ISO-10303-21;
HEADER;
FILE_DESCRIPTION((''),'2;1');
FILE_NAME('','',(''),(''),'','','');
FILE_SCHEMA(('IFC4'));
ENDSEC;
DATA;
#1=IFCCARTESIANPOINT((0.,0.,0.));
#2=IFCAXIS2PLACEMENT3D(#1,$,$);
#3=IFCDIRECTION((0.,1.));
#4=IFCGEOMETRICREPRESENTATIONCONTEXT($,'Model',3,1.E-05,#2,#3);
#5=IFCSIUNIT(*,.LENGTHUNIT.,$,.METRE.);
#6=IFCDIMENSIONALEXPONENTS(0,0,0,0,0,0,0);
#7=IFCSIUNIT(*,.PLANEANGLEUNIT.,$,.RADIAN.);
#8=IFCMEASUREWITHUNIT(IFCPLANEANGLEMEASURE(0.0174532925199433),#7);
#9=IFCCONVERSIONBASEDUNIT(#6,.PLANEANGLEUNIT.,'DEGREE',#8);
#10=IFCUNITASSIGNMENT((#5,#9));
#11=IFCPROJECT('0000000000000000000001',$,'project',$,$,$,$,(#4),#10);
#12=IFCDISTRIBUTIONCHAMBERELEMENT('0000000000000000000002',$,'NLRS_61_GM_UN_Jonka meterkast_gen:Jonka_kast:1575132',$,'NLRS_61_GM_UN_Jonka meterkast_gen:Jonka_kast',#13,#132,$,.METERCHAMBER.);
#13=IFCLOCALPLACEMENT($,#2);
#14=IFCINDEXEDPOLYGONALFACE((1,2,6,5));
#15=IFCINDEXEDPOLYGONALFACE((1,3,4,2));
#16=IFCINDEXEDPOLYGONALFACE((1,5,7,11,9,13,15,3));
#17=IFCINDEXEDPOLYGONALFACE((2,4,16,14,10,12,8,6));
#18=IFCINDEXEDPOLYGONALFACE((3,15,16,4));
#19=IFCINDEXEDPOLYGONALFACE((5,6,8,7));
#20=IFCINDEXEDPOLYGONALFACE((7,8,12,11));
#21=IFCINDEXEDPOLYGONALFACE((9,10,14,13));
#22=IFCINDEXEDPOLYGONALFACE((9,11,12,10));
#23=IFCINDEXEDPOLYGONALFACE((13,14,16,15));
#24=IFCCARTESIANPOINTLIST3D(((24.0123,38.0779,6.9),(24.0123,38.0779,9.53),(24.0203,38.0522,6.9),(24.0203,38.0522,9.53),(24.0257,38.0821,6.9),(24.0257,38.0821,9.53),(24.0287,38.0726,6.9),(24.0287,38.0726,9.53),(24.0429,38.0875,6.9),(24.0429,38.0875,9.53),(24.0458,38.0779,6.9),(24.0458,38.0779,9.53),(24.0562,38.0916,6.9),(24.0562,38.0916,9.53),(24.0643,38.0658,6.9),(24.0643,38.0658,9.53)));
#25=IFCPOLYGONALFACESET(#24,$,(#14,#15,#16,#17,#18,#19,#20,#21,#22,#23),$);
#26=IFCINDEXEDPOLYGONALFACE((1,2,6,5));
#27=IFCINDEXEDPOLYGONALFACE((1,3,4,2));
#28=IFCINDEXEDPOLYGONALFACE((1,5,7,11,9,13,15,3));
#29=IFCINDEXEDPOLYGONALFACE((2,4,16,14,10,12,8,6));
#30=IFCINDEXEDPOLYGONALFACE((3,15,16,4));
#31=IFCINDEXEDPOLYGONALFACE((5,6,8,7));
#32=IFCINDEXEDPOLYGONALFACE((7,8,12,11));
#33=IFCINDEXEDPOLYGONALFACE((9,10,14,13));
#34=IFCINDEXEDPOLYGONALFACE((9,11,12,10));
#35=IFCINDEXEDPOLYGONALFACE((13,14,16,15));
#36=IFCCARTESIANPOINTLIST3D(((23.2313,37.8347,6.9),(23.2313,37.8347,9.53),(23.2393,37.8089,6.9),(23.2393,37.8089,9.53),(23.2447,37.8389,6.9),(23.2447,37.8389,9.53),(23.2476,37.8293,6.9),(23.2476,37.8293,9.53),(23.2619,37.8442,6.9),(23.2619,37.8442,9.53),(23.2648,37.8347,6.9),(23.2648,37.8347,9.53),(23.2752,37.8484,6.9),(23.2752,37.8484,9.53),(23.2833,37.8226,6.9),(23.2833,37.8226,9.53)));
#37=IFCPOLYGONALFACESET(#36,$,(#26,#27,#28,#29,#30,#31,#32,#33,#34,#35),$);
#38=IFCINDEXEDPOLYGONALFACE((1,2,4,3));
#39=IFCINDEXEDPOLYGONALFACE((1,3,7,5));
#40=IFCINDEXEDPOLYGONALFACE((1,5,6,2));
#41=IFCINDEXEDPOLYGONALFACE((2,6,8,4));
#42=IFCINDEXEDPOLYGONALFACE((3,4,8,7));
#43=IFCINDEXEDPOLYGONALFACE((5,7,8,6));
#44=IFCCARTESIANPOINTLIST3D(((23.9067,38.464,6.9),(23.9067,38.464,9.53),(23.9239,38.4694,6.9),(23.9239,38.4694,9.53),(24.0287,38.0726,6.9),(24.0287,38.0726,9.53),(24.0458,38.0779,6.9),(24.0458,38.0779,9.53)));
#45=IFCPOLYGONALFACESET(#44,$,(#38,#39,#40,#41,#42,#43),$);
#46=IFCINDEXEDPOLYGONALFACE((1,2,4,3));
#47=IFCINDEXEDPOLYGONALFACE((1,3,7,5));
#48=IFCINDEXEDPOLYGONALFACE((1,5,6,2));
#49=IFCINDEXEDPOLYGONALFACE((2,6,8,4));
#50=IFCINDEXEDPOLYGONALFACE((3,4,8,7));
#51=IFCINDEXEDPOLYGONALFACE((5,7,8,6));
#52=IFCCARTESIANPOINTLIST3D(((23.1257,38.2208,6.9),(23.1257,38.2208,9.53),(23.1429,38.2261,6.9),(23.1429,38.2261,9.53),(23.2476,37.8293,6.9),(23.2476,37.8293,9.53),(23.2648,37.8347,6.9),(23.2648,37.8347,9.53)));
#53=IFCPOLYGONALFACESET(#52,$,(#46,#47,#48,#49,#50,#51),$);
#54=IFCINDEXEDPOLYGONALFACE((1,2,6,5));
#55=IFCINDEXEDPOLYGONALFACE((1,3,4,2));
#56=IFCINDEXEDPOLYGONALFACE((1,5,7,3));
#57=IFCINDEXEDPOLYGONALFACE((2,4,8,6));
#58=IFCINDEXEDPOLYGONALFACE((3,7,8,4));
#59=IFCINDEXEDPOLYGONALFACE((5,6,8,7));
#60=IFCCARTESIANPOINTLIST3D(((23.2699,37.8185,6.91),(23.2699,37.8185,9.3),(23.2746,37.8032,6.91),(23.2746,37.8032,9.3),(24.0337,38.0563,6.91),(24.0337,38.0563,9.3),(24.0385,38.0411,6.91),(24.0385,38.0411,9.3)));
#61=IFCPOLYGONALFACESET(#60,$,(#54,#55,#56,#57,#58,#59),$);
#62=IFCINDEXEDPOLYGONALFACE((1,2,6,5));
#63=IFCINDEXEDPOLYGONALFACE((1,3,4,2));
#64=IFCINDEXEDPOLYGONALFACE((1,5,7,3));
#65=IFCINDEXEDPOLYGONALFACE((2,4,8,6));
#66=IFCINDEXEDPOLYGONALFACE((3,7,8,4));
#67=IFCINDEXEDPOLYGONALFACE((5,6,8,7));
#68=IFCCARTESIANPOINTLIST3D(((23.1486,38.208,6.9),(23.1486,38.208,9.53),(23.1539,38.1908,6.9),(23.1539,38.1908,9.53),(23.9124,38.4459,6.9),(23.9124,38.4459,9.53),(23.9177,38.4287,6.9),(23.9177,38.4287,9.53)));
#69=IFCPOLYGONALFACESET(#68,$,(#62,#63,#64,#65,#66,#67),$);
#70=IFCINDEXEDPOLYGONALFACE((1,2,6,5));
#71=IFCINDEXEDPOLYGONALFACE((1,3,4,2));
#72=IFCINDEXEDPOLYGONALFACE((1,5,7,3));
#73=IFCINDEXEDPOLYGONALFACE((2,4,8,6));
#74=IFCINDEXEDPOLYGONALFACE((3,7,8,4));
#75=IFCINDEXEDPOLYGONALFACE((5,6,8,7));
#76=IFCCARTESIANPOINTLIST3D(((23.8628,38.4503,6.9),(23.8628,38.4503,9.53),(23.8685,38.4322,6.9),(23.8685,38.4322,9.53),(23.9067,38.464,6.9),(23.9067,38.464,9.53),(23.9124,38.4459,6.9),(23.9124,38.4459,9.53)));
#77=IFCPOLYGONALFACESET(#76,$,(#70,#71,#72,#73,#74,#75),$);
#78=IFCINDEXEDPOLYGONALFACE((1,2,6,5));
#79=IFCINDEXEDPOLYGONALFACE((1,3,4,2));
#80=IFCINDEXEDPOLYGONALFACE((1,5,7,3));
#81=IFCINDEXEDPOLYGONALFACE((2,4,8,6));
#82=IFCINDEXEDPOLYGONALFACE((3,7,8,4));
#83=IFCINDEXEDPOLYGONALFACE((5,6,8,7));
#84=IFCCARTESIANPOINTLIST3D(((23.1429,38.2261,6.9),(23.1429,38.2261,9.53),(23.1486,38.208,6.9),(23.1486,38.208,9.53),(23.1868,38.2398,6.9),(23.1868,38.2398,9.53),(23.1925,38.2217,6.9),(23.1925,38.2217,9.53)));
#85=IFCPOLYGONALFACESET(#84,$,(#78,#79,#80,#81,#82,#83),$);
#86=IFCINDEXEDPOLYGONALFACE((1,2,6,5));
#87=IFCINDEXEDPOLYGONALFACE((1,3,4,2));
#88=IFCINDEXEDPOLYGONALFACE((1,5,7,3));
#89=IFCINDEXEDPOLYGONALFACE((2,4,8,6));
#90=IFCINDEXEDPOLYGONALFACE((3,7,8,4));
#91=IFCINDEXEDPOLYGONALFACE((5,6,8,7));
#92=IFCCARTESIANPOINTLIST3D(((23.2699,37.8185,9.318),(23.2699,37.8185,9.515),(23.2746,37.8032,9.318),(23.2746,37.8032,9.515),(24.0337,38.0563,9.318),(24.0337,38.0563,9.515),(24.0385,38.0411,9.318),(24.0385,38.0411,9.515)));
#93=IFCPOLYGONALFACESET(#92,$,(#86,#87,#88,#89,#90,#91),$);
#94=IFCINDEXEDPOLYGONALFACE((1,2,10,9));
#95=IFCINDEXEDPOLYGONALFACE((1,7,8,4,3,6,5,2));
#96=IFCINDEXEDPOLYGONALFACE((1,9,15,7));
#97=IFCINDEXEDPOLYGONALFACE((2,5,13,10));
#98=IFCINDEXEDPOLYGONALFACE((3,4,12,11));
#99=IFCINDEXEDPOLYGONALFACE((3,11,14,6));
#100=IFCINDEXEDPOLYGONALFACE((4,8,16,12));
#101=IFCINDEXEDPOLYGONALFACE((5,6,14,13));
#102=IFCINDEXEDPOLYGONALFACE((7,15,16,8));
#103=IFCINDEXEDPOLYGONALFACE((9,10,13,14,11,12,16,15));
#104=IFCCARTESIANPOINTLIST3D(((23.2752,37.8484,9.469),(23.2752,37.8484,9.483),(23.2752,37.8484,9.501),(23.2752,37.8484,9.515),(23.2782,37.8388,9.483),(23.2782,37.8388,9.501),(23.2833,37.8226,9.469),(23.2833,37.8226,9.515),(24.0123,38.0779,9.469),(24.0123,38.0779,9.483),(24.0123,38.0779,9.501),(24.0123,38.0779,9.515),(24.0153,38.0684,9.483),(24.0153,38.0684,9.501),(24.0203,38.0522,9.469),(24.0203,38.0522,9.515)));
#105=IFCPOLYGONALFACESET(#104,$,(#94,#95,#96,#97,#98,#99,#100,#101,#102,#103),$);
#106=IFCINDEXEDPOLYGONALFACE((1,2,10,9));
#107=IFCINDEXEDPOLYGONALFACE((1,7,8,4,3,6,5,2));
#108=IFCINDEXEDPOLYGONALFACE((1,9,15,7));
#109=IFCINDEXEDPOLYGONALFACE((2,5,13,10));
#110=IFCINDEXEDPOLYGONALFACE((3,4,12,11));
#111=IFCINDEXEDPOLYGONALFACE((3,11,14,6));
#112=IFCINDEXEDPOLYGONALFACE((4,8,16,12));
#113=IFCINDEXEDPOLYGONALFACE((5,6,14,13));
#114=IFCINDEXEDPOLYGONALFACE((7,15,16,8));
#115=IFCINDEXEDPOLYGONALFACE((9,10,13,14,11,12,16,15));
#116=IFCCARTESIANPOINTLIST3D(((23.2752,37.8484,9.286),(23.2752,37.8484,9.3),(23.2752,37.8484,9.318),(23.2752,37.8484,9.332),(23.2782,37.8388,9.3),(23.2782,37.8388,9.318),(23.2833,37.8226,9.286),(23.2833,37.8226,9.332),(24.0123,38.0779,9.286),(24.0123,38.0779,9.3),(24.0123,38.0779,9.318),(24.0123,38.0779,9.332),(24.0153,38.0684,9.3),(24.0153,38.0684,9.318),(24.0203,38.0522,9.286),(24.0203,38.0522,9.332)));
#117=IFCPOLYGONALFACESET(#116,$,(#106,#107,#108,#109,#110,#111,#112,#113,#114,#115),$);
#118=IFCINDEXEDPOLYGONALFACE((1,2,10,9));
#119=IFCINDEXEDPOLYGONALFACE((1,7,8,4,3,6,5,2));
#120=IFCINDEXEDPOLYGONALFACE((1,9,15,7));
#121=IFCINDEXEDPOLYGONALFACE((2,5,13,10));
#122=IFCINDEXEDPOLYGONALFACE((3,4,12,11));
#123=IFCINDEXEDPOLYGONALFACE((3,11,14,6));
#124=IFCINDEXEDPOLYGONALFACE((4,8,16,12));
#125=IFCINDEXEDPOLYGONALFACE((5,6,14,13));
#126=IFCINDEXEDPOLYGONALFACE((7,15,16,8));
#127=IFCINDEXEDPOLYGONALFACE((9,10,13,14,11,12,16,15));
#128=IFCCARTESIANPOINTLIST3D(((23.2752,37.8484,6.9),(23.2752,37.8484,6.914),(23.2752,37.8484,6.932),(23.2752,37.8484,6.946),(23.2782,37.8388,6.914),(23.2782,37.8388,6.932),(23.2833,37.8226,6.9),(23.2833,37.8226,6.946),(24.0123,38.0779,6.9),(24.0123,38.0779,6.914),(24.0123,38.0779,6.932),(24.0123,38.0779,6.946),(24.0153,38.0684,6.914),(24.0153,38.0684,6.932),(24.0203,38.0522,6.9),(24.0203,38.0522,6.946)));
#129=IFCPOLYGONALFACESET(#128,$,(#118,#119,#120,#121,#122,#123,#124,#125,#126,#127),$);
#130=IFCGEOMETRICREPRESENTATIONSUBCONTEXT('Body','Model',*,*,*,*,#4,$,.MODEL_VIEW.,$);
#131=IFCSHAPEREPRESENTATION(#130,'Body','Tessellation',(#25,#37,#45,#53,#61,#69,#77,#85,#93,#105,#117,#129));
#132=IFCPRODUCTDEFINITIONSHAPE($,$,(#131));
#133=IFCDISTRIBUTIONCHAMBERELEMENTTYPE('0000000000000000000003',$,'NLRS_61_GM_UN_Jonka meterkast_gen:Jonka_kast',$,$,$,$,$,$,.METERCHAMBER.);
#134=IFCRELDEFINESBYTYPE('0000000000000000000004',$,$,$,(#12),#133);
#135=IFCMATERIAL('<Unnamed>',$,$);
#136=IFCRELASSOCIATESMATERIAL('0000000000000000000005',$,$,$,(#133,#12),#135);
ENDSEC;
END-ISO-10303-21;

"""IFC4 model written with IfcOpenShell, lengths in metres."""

from ifc_helpers import new_model, entity, si_unit, converted_unit, direction, frame, origin, place, context, subcontext, project, indexed_curve, outline, extrude, source, transform, mapped, material, type_object, element, save


model = new_model("IFC4")

# Units and contexts
model_context = context("Model", 3, precision=1e-05, world=origin(), true_north=direction((0.0, 1.0)))
body_context = subcontext(model_context, "Body", "Model", "MODEL_VIEW")
ifc_project = project(units=[si_unit("LENGTHUNIT", "METRE"), converted_unit("PLANEANGLEUNIT", "DEGREE", entity("IfcPlaneAngleMeasure", 0.0174532925199433), si_unit("PLANEANGLEUNIT", "RADIAN"), dimensions=[0, 0, 0, 0, 0, 0, 0])], contexts=[model_context])

# Shared definitions
ifc_material = material(Name="<Unnamed>")
distribution_chamber_element_type = type_object("IfcDistributionChamberElementType", Name="NLRS_61_GM_UN_Jonka meterkast_gen:Jonka_kast", PredefinedType="METERCHAMBER", material=ifc_material)
placement_1 = place(None, frame((13.1348, 11.9886, 0.0), z_axis=(0.0, 0.0, 1.0), x_axis=(0.954771, 0.297342, 0.0)))
placement_2 = place(placement_1, origin())
placement_3 = place(placement_2, frame((0.0, 0.0, 6.9)))

# Distribution chamber element
shared_shape_1 = source(origin(), body_context, "Body", "SweptSolid", [
    extrude(outline(indexed_curve([(-0.023, -0.0093), (-0.009, -0.0093), (-0.009, 0.0007), (0.009, 0.0007), (0.009, -0.0093), (0.023, -0.0093), (0.023, 0.0178), (-0.023, 0.0178), (-0.023, -0.0093)], self_intersect=False)), frame((-0.409, 0.4092, 0.0)), (0.0, 0.0, 1.0), 2.63),
    extrude(outline(indexed_curve([(-0.023, -0.0093), (-0.009, -0.0093), (-0.009, 0.0007), (0.009, 0.0007), (0.009, -0.0093), (0.023, -0.0093), (0.023, 0.0178), (-0.023, 0.0178), (-0.023, -0.0093)], self_intersect=False)), frame((0.409, 0.4092, 0.0)), (0.0, 0.0, 1.0), 2.63),
    extrude(outline(indexed_curve([(-0.009, -0.205), (0.009, -0.205), (0.009, 0.205), (-0.009, 0.205), (-0.009, -0.205)], self_intersect=False)), frame((-0.409, 0.205, 0.0)), (0.0, 0.0, 1.0), 2.63),
    extrude(outline(indexed_curve([(-0.009, -0.205), (0.009, -0.205), (0.009, 0.205), (-0.009, 0.205), (-0.009, -0.205)], self_intersect=False)), frame((0.409, 0.205, 0.0)), (0.0, 0.0, 1.0), 2.63),
    extrude(outline(indexed_curve([(-0.008, -0.4), (0.008, -0.4), (0.008, 0.4), (-0.008, 0.4), (-0.008, -0.4)], self_intersect=False)), frame((0.0, 0.435, 0.01), z_axis=(0.0, 0.0, 1.0), x_axis=(0.0, 1.0, 0.0)), (0.0, 0.0, 1.0), 2.39),
    extrude(outline(indexed_curve([(-0.009, -0.4), (0.009, -0.4), (0.009, 0.4), (-0.009, 0.4), (-0.009, -0.4)], self_intersect=False)), frame((0.0, 0.028, 0.0), z_axis=(0.0, 0.0, 1.0), x_axis=(0.0, 1.0, 0.0)), (0.0, 0.0, 1.0), 2.63),
    extrude(outline(indexed_curve([(-0.0095, -0.023), (0.0095, -0.023), (0.0095, 0.023), (-0.0095, 0.023), (-0.0095, -0.023)], self_intersect=False)), frame((-0.377, 0.0095, 0.0), z_axis=(0.0, 0.0, 1.0), x_axis=(0.0, 1.0, 0.0)), (0.0, 0.0, 1.0), 2.63),
    extrude(outline(indexed_curve([(-0.0095, -0.023), (0.0095, -0.023), (0.0095, 0.023), (-0.0095, 0.023), (-0.0095, -0.023)], self_intersect=False)), frame((0.377, 0.0095, 0.0), z_axis=(0.0, 0.0, 1.0), x_axis=(0.0, 1.0, 0.0)), (0.0, 0.0, 1.0), 2.63),
    extrude(outline(indexed_curve([(-0.008, -0.4), (0.008, -0.4), (0.008, 0.4), (-0.008, 0.4), (-0.008, -0.4)], self_intersect=False)), frame((0.0, 0.435, 2.418), z_axis=(0.0, 0.0, 1.0), x_axis=(0.0, 1.0, 0.0)), (0.0, 0.0, 1.0), 0.197),
    extrude(outline(indexed_curve([(-0.0178, -0.023), (0.0093, -0.023), (0.0093, -0.009), (-0.0007, -0.009), (-0.0007, 0.009), (0.0093, 0.009), (0.0093, 0.023), (-0.0178, 0.023), (-0.0178, -0.023)], self_intersect=False)), frame((-0.386, 0.4092, 2.592), z_axis=(1.0, 0.0, 0.0), x_axis=(0.0, -1.0, 0.0)), (0.0, 0.0, 1.0), 0.772),
    extrude(outline(indexed_curve([(-0.0178, -0.023), (0.0093, -0.023), (0.0093, -0.009), (-0.0007, -0.009), (-0.0007, 0.009), (0.0093, 0.009), (0.0093, 0.023), (-0.0178, 0.023), (-0.0178, -0.023)], self_intersect=False)), frame((-0.386, 0.4092, 2.409), z_axis=(1.0, 0.0, 0.0), x_axis=(0.0, -1.0, 0.0)), (0.0, 0.0, 1.0), 0.772),
    extrude(outline(indexed_curve([(-0.0178, -0.023), (0.0093, -0.023), (0.0093, -0.009), (-0.0007, -0.009), (-0.0007, 0.009), (0.0093, 0.009), (0.0093, 0.023), (-0.0178, 0.023), (-0.0178, -0.023)], self_intersect=False)), frame((-0.386, 0.4092, 0.023), z_axis=(1.0, 0.0, 0.0), x_axis=(0.0, -1.0, 0.0)), (0.0, 0.0, 1.0), 0.772),
])
placement_4 = place(placement_3, origin())
distribution_chamber_element_1_placement = place(placement_4, frame((17.757, 22.075, 0.0), z_axis=(0.0, 0.0, 1.0), x_axis=(-1.0, 0.0, 0.0)))
element("IfcDistributionChamberElement", 1, at=distribution_chamber_element_1_placement, type_object=distribution_chamber_element_type, material=ifc_material, Name="NLRS_61_GM_UN_Jonka meterkast_gen:Jonka_kast:1575132", ObjectType="NLRS_61_GM_UN_Jonka meterkast_gen:Jonka_kast", PredefinedType="METERCHAMBER", context=body_context, shape_type="MappedRepresentation", body=[
    mapped(shared_shape_1, transform((0.0, 0.0, 0.0), scale=1.0)),
])

save(model, "model.ifc")
